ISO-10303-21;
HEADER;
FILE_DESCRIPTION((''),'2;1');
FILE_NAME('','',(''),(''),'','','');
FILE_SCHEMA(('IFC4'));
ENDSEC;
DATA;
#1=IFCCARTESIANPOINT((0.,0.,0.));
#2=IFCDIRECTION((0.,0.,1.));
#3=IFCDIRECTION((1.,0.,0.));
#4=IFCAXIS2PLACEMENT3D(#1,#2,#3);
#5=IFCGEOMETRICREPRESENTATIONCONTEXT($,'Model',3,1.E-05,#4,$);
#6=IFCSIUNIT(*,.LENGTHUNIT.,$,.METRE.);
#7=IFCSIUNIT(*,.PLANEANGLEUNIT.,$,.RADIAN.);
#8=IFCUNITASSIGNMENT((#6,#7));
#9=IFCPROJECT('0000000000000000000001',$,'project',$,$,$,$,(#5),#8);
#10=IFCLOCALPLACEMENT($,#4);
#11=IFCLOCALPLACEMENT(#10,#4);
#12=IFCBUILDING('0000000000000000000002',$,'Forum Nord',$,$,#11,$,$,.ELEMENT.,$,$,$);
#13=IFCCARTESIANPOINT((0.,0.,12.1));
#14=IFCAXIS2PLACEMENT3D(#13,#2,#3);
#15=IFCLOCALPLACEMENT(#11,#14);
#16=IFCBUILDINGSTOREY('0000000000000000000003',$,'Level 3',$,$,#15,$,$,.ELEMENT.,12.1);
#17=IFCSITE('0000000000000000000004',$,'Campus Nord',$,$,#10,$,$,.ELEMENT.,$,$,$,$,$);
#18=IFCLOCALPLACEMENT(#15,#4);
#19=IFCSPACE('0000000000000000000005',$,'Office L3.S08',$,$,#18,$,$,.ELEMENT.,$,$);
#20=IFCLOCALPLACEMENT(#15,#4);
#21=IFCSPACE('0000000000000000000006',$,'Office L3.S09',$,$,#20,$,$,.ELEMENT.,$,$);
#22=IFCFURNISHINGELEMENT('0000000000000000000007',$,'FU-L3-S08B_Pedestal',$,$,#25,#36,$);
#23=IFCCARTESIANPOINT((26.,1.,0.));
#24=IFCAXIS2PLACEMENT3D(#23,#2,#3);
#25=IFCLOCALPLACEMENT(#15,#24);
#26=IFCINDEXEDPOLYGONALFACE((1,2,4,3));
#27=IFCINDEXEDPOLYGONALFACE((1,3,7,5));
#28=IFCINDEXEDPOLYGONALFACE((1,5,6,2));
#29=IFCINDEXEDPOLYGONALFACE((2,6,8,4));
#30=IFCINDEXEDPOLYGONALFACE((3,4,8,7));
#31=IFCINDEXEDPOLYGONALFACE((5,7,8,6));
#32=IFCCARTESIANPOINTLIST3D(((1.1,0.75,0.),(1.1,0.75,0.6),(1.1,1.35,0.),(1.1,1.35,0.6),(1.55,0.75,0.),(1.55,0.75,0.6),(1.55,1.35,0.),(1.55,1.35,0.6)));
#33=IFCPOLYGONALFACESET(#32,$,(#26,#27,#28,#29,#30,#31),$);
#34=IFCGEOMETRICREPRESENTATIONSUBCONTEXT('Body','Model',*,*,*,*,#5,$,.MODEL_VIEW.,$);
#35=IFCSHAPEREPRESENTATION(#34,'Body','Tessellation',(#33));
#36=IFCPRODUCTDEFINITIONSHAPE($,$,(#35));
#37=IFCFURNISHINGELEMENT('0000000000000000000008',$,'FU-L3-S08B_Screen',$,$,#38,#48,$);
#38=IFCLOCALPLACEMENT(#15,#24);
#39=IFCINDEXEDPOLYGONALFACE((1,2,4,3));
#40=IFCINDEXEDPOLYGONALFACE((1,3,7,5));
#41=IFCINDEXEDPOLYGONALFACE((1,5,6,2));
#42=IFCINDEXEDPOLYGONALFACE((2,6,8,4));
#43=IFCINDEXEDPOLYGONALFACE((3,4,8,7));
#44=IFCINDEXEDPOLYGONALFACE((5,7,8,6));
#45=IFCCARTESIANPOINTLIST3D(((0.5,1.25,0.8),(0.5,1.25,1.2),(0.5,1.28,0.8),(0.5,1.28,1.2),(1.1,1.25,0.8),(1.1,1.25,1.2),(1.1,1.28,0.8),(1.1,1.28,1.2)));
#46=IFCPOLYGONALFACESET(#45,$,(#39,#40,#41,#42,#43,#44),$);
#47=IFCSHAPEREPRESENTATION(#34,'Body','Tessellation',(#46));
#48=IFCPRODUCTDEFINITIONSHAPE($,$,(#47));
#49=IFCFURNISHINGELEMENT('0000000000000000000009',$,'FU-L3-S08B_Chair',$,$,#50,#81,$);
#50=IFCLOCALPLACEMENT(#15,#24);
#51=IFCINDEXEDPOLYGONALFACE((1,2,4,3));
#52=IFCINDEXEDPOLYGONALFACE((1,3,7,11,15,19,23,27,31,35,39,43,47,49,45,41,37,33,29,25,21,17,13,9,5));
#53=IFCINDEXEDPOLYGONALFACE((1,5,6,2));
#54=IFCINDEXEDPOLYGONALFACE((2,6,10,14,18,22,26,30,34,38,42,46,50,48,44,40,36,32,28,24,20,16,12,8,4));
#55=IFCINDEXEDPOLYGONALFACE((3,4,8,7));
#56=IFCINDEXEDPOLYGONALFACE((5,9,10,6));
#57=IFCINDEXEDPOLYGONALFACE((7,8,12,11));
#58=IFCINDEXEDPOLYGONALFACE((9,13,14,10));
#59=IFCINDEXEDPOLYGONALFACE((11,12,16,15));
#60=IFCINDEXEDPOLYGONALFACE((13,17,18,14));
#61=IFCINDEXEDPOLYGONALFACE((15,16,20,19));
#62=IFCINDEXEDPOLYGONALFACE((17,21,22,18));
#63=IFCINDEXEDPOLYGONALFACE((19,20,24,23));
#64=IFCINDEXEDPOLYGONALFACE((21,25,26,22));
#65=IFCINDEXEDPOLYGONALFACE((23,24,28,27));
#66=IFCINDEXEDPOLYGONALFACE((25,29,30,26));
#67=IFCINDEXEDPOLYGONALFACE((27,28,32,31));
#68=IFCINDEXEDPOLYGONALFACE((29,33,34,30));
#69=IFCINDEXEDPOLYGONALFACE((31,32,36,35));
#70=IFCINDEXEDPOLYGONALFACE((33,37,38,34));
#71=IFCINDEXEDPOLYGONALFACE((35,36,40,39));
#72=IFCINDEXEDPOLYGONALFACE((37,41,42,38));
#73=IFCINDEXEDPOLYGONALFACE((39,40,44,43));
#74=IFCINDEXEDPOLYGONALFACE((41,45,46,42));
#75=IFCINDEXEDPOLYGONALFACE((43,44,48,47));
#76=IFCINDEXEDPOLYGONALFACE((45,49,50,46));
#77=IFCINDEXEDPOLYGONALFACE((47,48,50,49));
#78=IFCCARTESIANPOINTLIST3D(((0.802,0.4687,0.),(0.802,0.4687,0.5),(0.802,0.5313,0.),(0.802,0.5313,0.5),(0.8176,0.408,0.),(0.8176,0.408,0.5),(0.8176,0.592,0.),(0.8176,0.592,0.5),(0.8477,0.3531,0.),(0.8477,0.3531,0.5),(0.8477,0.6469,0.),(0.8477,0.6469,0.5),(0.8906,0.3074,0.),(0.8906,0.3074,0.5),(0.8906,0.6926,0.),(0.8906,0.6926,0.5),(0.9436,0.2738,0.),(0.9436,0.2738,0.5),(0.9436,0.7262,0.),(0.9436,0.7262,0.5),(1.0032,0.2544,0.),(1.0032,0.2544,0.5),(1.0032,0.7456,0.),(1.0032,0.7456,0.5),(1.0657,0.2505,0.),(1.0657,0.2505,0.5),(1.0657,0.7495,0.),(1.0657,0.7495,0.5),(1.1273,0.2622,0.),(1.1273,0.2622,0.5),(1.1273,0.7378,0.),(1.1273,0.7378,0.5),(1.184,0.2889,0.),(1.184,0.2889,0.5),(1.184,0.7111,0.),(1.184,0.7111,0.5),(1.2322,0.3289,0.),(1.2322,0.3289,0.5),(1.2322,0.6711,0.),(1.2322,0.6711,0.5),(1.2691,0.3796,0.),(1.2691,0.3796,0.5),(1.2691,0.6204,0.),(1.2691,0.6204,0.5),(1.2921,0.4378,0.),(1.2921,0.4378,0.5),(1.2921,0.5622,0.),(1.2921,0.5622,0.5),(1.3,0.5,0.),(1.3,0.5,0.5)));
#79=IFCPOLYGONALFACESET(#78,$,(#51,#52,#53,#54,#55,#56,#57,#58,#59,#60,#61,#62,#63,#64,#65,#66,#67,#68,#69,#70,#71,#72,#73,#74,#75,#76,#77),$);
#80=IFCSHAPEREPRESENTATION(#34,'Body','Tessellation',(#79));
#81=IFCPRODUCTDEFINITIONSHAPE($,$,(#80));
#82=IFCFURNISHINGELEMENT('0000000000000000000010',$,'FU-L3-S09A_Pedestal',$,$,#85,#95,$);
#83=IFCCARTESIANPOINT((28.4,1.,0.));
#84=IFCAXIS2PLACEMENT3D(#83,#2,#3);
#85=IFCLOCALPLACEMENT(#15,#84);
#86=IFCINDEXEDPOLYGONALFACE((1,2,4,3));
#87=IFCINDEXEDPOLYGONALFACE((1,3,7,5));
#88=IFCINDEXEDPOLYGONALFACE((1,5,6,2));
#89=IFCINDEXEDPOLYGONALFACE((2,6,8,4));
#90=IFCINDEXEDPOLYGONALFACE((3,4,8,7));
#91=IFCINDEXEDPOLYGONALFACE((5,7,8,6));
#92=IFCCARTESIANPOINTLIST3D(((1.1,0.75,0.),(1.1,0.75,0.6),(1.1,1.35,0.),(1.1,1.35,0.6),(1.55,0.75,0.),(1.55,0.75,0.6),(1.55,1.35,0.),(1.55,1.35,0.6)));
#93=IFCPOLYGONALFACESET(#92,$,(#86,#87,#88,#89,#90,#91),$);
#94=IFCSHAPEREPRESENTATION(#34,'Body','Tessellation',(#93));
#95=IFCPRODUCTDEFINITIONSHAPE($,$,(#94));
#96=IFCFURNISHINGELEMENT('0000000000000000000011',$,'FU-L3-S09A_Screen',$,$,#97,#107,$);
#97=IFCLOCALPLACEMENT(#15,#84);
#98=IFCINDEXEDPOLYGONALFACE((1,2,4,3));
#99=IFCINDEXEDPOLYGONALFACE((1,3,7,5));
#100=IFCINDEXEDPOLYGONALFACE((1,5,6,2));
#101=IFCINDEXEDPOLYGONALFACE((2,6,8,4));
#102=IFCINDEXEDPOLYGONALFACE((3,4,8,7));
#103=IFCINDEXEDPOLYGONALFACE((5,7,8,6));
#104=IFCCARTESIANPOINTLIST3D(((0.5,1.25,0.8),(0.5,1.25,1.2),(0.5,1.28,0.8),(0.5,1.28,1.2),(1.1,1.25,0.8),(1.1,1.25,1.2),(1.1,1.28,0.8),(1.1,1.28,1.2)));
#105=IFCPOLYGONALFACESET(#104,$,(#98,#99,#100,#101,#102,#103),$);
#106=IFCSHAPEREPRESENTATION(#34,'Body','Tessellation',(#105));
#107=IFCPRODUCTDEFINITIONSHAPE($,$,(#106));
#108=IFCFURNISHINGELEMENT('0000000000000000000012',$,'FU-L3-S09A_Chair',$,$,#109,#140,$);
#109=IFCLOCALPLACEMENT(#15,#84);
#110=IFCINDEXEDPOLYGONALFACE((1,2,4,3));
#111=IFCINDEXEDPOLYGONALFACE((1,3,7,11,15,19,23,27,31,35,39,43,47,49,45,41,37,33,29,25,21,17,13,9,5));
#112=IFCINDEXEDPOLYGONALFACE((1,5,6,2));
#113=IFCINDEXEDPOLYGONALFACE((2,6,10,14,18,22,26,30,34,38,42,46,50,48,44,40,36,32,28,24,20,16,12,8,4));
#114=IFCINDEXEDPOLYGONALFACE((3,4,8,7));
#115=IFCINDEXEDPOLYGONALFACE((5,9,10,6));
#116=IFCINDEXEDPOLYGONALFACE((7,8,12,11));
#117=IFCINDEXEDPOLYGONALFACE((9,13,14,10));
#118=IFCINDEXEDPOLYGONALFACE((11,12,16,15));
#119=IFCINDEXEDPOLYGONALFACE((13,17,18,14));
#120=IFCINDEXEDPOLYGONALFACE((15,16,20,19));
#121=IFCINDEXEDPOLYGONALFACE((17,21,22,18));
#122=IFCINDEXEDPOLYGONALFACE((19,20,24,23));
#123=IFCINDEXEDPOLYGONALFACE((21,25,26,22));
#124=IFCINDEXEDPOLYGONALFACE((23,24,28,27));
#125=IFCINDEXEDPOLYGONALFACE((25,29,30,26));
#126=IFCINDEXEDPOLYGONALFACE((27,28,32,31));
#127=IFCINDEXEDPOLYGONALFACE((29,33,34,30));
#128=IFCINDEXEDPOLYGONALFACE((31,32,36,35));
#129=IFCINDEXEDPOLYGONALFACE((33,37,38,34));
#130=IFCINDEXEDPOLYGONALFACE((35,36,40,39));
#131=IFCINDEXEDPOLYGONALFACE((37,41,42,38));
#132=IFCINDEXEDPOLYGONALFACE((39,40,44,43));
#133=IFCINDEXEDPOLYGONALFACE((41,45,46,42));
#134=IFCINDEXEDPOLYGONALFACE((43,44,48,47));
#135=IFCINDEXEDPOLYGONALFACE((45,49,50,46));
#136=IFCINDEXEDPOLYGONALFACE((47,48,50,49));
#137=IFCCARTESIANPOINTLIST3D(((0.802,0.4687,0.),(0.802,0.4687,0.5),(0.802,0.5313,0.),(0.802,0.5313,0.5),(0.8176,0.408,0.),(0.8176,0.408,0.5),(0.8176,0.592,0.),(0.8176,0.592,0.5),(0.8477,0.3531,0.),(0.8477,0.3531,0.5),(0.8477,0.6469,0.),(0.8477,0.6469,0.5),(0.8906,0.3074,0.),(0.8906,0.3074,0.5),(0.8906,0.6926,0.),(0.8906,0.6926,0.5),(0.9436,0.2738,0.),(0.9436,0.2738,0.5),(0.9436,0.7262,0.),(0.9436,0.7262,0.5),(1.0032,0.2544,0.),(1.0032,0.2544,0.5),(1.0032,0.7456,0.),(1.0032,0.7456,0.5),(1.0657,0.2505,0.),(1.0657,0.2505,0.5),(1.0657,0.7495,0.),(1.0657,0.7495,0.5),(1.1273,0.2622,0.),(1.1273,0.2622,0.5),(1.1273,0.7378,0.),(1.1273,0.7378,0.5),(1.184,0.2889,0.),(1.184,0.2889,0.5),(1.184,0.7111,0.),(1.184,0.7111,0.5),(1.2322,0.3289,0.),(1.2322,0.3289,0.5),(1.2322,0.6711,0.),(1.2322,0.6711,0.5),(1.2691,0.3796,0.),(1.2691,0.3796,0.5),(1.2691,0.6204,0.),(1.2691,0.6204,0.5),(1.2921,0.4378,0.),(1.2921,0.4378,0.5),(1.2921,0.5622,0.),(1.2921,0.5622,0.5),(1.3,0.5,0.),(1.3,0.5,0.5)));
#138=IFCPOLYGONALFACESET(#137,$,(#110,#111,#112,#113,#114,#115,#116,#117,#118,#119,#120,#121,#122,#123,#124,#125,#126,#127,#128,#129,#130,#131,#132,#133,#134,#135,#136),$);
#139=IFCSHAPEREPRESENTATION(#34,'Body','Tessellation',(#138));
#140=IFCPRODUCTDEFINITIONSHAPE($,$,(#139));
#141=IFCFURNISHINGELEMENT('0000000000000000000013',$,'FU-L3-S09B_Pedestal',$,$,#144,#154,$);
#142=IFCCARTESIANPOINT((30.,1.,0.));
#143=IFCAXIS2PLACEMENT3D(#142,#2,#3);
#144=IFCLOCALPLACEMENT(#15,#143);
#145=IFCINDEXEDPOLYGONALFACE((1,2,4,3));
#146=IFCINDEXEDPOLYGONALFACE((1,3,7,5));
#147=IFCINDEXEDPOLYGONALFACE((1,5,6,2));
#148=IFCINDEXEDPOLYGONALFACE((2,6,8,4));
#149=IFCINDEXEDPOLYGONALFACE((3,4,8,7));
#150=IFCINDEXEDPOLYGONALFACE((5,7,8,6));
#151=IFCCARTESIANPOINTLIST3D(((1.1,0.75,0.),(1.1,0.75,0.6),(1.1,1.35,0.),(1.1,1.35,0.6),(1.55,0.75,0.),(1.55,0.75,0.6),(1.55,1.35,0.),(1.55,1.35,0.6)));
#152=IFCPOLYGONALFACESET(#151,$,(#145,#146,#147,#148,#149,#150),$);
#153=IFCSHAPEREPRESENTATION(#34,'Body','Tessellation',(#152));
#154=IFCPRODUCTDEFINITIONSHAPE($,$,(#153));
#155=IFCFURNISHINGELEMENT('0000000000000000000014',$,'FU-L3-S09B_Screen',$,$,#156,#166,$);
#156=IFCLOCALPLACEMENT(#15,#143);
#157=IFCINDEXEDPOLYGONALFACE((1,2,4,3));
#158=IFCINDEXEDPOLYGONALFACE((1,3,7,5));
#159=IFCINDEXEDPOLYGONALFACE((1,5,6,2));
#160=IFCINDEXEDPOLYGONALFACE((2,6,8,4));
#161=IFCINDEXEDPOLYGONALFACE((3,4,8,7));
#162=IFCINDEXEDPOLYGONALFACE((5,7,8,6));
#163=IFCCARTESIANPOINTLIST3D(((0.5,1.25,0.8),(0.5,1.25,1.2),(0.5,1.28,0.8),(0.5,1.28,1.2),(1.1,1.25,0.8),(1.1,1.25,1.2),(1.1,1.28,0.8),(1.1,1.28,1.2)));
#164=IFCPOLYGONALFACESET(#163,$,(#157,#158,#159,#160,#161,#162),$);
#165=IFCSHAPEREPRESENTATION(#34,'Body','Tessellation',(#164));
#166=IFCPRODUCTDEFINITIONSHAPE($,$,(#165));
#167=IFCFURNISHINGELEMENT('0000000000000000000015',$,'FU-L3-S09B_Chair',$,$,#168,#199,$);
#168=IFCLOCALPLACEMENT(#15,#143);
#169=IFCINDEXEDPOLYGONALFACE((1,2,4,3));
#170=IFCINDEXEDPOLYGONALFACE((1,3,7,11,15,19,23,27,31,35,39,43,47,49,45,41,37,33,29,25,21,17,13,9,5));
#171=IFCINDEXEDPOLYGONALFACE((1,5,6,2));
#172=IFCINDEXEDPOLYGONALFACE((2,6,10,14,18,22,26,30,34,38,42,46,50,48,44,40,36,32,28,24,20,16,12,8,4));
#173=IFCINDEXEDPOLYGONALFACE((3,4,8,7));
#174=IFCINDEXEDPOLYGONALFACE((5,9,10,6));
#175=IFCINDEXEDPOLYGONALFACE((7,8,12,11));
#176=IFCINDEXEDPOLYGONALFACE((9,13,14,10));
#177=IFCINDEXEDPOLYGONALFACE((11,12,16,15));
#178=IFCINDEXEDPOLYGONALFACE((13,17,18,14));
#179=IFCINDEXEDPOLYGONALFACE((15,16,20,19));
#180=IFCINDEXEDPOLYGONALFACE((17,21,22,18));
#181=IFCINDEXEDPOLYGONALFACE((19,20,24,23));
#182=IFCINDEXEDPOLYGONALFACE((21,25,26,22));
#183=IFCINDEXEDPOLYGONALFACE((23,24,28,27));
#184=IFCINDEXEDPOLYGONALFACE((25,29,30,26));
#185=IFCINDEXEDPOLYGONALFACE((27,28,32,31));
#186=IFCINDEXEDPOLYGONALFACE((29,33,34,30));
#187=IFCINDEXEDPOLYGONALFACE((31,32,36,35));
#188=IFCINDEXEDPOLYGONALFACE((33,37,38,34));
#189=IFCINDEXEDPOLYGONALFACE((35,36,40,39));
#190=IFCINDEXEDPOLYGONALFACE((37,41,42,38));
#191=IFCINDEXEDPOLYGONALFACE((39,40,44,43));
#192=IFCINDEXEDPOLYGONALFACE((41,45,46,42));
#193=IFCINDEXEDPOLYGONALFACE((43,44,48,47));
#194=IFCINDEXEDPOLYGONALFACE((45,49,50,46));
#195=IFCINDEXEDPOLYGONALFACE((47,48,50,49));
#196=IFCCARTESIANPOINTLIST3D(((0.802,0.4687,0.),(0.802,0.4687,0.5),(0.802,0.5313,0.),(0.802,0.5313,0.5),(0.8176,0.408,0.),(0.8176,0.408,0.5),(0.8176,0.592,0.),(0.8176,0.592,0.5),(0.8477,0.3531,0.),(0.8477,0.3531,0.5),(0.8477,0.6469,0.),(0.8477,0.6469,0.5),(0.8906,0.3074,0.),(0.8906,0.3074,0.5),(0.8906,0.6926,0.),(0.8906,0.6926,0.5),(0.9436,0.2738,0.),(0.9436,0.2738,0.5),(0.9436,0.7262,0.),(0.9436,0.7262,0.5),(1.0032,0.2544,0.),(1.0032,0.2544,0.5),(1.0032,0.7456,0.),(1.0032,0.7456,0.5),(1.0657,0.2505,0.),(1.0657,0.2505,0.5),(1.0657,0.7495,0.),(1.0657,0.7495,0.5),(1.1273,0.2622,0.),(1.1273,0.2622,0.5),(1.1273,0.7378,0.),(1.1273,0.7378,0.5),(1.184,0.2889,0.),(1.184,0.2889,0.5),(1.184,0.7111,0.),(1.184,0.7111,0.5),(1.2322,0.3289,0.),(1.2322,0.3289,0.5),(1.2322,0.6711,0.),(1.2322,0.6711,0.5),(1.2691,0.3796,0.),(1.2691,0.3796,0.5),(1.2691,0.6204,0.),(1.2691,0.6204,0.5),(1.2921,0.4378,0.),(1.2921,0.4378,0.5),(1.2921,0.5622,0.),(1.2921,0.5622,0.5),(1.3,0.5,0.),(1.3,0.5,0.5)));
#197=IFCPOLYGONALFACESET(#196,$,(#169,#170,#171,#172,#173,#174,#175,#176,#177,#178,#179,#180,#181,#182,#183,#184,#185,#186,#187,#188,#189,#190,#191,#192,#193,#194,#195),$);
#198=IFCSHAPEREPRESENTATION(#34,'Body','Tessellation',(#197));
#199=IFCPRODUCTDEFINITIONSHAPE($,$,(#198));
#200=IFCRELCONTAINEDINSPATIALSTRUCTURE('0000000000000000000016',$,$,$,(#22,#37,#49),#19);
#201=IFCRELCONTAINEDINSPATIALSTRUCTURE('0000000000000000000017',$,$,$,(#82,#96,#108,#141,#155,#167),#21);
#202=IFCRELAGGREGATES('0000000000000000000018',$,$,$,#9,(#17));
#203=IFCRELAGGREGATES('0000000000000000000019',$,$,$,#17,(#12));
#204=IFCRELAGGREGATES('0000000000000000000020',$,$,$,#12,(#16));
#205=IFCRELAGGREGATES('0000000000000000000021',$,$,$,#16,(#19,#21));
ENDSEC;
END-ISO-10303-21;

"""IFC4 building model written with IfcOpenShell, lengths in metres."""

from ifc_helpers import new_model, si_unit, frame, frame_2d, origin_with_axes, place, context, subcontext, project, spatial, rectangle, circle, extrude, element, save


model = new_model("IFC4")

# Units and contexts
model_context = context("Model", 3, precision=1e-05, world=origin_with_axes())
body_context = subcontext(model_context, "Body", "Model", "MODEL_VIEW")
ifc_project = project(units=[si_unit("LENGTHUNIT", "METRE"), si_unit("PLANEANGLEUNIT", "RADIAN")], contexts=[model_context])

# Site, building, storey
site_placement = place(None, origin_with_axes())
site = spatial("IfcSite", under=ifc_project, at=site_placement, Name="Campus Nord", CompositionType="ELEMENT")
building_placement = place(site_placement, origin_with_axes())
building = spatial("IfcBuilding", under=site, at=building_placement, Name="Forum Nord", CompositionType="ELEMENT")
storey_placement = place(building_placement, frame((0.0, 0.0, 12.1), z_axis=(0.0, 0.0, 1.0), x_axis=(1.0, 0.0, 0.0)))
storey = spatial("IfcBuildingStorey", under=building, at=storey_placement, Name="Level 3", CompositionType="ELEMENT", Elevation=12.1)

# Shared definitions
space_1_placement = place(storey_placement, origin_with_axes())
space_1 = spatial("IfcSpace", under=storey, at=space_1_placement, Name="Office L3.S08", CompositionType="ELEMENT")

# Furnishing elements
furnishing_1_placement = place(storey_placement, frame((26.0, 1.0, 0.0), z_axis=(0.0, 0.0, 1.0), x_axis=(1.0, 0.0, 0.0)))
element("IfcFurnishingElement", 1, at=furnishing_1_placement, inside=space_1, Name="FU-L3-S08B_Pedestal", context=body_context, shape_type="SweptSolid", body=[
    extrude(rectangle(XDim=0.45, YDim=0.6, at=frame_2d((1.325, 1.05), x_axis=(1.0, 0.0))), origin_with_axes(), (0.0, 0.0, 1.0), 0.6),
])
furnishing_2_placement = place(storey_placement, frame((26.0, 1.0, 0.0), z_axis=(0.0, 0.0, 1.0), x_axis=(1.0, 0.0, 0.0)))
element("IfcFurnishingElement", 2, at=furnishing_2_placement, inside=space_1, Name="FU-L3-S08B_Screen", context=body_context, shape_type="SweptSolid", body=[
    extrude(rectangle(XDim=0.6, YDim=0.03, at=frame_2d((0.8, 1.265), x_axis=(1.0, 0.0))), frame((0.0, 0.0, 0.8), z_axis=(0.0, 0.0, 1.0), x_axis=(1.0, 0.0, 0.0)), (0.0, 0.0, 1.0), 0.4),
])
furnishing_3_placement = place(storey_placement, frame((26.0, 1.0, 0.0), z_axis=(0.0, 0.0, 1.0), x_axis=(1.0, 0.0, 0.0)))
element("IfcFurnishingElement", 3, at=furnishing_3_placement, inside=space_1, Name="FU-L3-S08B_Chair", context=body_context, shape_type="SweptSolid", body=[
    extrude(circle(Radius=0.25, at=frame_2d((1.05, 0.5), x_axis=(1.0, 0.0))), origin_with_axes(), (0.0, 0.0, 1.0), 0.5),
])

# Shared definitions
space_2_placement = place(storey_placement, origin_with_axes())
space_2 = spatial("IfcSpace", under=storey, at=space_2_placement, Name="Office L3.S09", CompositionType="ELEMENT")

# Furnishing elements
furnishing_4_placement = place(storey_placement, frame((28.4, 1.0, 0.0), z_axis=(0.0, 0.0, 1.0), x_axis=(1.0, 0.0, 0.0)))
element("IfcFurnishingElement", 4, at=furnishing_4_placement, inside=space_2, Name="FU-L3-S09A_Pedestal", context=body_context, shape_type="SweptSolid", body=[
    extrude(rectangle(XDim=0.45, YDim=0.6, at=frame_2d((1.325, 1.05), x_axis=(1.0, 0.0))), origin_with_axes(), (0.0, 0.0, 1.0), 0.6),
])
furnishing_5_placement = place(storey_placement, frame((28.4, 1.0, 0.0), z_axis=(0.0, 0.0, 1.0), x_axis=(1.0, 0.0, 0.0)))
element("IfcFurnishingElement", 5, at=furnishing_5_placement, inside=space_2, Name="FU-L3-S09A_Screen", context=body_context, shape_type="SweptSolid", body=[
    extrude(rectangle(XDim=0.6, YDim=0.03, at=frame_2d((0.8, 1.265), x_axis=(1.0, 0.0))), frame((0.0, 0.0, 0.8), z_axis=(0.0, 0.0, 1.0), x_axis=(1.0, 0.0, 0.0)), (0.0, 0.0, 1.0), 0.4),
])
furnishing_6_placement = place(storey_placement, frame((28.4, 1.0, 0.0), z_axis=(0.0, 0.0, 1.0), x_axis=(1.0, 0.0, 0.0)))
element("IfcFurnishingElement", 6, at=furnishing_6_placement, inside=space_2, Name="FU-L3-S09A_Chair", context=body_context, shape_type="SweptSolid", body=[
    extrude(circle(Radius=0.25, at=frame_2d((1.05, 0.5), x_axis=(1.0, 0.0))), origin_with_axes(), (0.0, 0.0, 1.0), 0.5),
])
furnishing_7_placement = place(storey_placement, frame((30.0, 1.0, 0.0), z_axis=(0.0, 0.0, 1.0), x_axis=(1.0, 0.0, 0.0)))
element("IfcFurnishingElement", 7, at=furnishing_7_placement, inside=space_2, Name="FU-L3-S09B_Pedestal", context=body_context, shape_type="SweptSolid", body=[
    extrude(rectangle(XDim=0.45, YDim=0.6, at=frame_2d((1.325, 1.05), x_axis=(1.0, 0.0))), origin_with_axes(), (0.0, 0.0, 1.0), 0.6),
])
furnishing_8_placement = place(storey_placement, frame((30.0, 1.0, 0.0), z_axis=(0.0, 0.0, 1.0), x_axis=(1.0, 0.0, 0.0)))
element("IfcFurnishingElement", 8, at=furnishing_8_placement, inside=space_2, Name="FU-L3-S09B_Screen", context=body_context, shape_type="SweptSolid", body=[
    extrude(rectangle(XDim=0.6, YDim=0.03, at=frame_2d((0.8, 1.265), x_axis=(1.0, 0.0))), frame((0.0, 0.0, 0.8), z_axis=(0.0, 0.0, 1.0), x_axis=(1.0, 0.0, 0.0)), (0.0, 0.0, 1.0), 0.4),
])
furnishing_9_placement = place(storey_placement, frame((30.0, 1.0, 0.0), z_axis=(0.0, 0.0, 1.0), x_axis=(1.0, 0.0, 0.0)))
element("IfcFurnishingElement", 9, at=furnishing_9_placement, inside=space_2, Name="FU-L3-S09B_Chair", context=body_context, shape_type="SweptSolid", body=[
    extrude(circle(Radius=0.25, at=frame_2d((1.05, 0.5), x_axis=(1.0, 0.0))), origin_with_axes(), (0.0, 0.0, 1.0), 0.5),
])

save(model, "model.ifc")
